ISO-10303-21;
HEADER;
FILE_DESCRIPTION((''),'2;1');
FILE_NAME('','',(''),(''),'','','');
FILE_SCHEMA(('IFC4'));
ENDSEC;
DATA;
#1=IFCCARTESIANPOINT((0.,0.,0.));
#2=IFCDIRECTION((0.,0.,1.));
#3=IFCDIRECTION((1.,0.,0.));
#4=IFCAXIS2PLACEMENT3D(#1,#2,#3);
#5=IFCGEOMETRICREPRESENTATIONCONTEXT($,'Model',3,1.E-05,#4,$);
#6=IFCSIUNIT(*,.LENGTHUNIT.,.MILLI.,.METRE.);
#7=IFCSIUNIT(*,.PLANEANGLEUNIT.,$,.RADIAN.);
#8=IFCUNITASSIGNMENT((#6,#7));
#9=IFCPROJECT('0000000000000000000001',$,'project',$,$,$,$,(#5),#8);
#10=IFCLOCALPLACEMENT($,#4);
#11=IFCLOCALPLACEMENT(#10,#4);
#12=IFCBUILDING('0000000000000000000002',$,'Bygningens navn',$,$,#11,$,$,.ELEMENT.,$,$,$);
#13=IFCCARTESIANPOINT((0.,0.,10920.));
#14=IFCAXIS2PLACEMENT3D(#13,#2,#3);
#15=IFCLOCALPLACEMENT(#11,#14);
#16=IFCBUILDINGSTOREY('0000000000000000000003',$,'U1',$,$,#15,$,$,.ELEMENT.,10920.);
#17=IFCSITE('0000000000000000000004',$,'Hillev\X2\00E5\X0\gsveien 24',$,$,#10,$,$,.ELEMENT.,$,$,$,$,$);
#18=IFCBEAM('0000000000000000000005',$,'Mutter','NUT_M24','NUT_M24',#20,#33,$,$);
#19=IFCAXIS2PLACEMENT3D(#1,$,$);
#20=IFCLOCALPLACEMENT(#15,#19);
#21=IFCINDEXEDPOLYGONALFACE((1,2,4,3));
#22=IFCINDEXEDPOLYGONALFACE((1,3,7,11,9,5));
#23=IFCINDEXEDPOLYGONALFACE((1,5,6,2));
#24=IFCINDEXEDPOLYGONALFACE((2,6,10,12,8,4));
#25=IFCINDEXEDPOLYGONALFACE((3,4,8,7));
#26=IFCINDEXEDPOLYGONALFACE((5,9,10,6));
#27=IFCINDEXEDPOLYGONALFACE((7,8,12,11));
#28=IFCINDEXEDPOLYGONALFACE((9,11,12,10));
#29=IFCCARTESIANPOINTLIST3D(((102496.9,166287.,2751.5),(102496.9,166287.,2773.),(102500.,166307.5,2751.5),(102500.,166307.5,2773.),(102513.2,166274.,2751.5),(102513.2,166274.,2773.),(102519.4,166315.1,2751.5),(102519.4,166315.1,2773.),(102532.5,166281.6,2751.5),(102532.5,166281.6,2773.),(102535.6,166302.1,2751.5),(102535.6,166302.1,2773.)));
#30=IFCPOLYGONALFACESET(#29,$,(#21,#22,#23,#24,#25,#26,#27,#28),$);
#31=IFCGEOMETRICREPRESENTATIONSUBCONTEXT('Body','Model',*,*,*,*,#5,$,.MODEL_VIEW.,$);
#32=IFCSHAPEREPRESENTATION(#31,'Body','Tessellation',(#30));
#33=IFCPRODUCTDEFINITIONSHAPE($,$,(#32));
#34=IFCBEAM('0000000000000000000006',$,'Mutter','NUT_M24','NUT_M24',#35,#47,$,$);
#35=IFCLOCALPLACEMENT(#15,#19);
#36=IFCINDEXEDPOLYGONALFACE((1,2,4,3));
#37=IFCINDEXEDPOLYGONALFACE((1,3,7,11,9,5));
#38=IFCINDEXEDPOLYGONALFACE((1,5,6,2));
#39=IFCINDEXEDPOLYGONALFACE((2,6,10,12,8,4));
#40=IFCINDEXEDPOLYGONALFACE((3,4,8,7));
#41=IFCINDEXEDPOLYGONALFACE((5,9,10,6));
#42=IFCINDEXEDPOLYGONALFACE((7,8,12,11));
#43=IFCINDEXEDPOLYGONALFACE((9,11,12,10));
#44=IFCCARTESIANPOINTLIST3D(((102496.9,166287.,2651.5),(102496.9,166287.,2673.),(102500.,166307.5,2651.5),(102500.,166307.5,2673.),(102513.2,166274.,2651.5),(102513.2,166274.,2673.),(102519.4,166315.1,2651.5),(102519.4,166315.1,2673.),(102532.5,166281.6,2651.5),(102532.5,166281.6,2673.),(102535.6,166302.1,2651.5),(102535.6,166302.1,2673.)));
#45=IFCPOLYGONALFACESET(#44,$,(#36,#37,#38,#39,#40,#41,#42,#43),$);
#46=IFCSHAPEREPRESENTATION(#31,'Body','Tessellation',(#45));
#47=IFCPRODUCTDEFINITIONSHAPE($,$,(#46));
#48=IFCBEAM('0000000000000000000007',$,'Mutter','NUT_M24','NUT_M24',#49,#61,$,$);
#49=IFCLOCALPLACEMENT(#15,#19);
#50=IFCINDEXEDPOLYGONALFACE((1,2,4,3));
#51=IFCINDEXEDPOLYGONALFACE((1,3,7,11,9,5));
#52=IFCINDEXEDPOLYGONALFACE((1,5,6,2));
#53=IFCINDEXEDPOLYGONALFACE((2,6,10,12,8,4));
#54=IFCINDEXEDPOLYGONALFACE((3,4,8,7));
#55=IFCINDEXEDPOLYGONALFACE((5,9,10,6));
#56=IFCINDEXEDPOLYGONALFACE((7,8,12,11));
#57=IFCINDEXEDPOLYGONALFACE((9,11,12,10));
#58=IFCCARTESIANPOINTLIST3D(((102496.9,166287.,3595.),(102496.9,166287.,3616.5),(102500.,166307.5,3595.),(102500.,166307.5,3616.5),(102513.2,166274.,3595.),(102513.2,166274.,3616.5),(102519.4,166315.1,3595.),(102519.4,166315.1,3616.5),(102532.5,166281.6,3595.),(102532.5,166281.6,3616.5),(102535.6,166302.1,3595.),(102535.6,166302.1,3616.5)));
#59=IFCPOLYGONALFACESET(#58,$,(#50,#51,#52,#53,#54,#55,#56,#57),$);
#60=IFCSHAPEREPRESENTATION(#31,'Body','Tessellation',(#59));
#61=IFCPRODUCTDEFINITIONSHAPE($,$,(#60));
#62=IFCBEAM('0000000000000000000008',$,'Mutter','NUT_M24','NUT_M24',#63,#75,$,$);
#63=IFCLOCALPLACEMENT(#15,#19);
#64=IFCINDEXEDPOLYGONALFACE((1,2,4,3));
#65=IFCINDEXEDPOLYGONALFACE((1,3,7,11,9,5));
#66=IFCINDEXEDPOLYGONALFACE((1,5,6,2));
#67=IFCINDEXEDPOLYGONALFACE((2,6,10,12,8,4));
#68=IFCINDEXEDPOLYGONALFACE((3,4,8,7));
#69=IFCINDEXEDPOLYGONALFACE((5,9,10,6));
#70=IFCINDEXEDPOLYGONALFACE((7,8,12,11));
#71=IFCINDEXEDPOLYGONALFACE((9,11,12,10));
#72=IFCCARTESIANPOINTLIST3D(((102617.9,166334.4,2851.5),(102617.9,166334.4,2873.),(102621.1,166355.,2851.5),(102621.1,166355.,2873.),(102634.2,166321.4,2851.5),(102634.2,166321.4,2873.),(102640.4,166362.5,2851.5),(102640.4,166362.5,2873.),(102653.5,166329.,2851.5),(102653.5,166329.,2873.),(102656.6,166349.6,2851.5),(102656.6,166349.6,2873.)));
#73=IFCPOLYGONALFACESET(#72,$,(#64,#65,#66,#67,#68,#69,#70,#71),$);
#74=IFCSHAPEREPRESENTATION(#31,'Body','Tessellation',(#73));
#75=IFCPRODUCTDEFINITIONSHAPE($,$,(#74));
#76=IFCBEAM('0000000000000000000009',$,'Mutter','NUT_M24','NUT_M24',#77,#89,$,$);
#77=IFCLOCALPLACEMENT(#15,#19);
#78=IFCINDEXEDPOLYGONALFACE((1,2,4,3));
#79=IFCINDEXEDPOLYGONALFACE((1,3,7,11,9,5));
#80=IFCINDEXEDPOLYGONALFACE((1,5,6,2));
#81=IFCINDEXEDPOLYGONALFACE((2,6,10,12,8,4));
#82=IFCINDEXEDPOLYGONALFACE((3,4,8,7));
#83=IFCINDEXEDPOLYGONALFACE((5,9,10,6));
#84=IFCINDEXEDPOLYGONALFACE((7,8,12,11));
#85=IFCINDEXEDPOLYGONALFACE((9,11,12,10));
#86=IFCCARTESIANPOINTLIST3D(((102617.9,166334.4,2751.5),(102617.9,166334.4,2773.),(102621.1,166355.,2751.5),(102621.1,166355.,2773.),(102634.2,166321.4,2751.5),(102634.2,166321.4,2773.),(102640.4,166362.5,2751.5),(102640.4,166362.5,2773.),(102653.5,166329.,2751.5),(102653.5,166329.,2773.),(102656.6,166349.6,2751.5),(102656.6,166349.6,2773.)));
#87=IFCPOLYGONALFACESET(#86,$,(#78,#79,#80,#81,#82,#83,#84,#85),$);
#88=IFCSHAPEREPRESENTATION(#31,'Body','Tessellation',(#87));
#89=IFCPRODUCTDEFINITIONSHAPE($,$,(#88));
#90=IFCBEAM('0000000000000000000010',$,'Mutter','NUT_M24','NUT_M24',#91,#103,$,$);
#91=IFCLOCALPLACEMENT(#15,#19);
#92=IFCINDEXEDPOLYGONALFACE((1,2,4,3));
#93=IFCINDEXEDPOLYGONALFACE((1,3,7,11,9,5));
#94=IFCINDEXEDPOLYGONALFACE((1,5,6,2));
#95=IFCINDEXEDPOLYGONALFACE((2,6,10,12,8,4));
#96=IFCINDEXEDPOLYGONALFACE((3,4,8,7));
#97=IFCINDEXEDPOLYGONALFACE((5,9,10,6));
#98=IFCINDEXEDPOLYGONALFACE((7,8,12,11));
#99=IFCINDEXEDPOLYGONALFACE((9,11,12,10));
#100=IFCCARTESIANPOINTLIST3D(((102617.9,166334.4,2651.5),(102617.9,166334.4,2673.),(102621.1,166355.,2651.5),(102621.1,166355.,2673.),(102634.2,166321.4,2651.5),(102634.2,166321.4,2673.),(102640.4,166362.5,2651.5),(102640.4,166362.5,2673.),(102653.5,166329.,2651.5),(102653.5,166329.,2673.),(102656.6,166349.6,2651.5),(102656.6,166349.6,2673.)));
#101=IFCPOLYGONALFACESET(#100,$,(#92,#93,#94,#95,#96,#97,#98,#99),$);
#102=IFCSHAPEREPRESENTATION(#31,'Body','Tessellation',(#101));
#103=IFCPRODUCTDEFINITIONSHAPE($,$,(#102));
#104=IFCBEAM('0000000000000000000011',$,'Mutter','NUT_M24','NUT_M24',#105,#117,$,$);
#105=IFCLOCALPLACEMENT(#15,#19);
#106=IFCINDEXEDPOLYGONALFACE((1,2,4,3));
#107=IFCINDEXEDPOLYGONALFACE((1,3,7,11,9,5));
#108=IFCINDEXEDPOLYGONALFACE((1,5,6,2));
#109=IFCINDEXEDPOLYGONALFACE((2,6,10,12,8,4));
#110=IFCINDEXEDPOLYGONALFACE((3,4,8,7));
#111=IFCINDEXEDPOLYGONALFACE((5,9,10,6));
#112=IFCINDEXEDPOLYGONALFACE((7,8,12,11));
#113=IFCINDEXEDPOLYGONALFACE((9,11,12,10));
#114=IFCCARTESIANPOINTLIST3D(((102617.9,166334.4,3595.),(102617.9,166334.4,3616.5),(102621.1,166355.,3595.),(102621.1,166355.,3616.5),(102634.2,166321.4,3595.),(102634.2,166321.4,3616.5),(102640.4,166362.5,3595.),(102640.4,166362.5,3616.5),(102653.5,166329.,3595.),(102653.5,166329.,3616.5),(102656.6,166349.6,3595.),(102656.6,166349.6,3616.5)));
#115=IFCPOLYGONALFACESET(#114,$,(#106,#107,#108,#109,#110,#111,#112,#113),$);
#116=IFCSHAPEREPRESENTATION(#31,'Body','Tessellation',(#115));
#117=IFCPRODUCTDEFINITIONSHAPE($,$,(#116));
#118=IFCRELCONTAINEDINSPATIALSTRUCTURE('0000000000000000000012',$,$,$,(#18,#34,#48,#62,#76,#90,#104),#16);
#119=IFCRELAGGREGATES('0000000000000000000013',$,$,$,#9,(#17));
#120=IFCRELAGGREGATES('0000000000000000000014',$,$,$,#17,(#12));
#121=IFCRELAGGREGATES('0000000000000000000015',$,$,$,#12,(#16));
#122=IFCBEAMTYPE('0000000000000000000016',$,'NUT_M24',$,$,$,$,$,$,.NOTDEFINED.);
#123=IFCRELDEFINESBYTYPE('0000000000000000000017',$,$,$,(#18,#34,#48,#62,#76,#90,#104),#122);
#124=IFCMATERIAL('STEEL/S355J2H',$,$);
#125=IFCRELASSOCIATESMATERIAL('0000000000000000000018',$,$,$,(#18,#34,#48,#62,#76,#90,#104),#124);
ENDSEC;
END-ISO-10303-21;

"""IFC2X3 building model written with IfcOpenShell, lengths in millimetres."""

from ifc_helpers import new_model, si_unit, frame, origin_with_axes, place, context, subcontext, project, spatial, polyline, outline, extrude, material, type_object, element, save


model = new_model("IFC2X3")

# Units and contexts
model_context = context("Model", 3, precision=1e-05, world=origin_with_axes())
body_context = subcontext(model_context, "Body", "Model", "MODEL_VIEW")
ifc_project = project(units=[si_unit("LENGTHUNIT", "METRE", prefix="MILLI"), si_unit("PLANEANGLEUNIT", "RADIAN")], contexts=[model_context])

# Site, building, storey
site_placement = place(None, origin_with_axes())
site = spatial("IfcSite", under=ifc_project, at=site_placement, Name="Hillevågsveien 24", CompositionType="ELEMENT")
building_placement = place(site_placement, origin_with_axes())
building = spatial("IfcBuilding", under=site, at=building_placement, Name="Bygningens navn", CompositionType="ELEMENT")
storey_placement = place(building_placement, frame((0.0, 0.0, 10920.0), z_axis=(0.0, 0.0, 1.0), x_axis=(1.0, 0.0, 0.0)))
storey = spatial("IfcBuildingStorey", under=building, at=storey_placement, Name="U1", CompositionType="ELEMENT", Elevation=10920.0)

# Beams
ifc_material_1 = material(Name="STEEL/S355J2H")
beam_type_1 = type_object("IfcBeamType", Name="NUT_M24", PredefinedType="NOTDEFINED")
for number, where, z_axis, x_axis, name in (
    (1, (102516.3, 166294.6, 2773.0), (-0.364877, 0.931056, 0.0), (0.0, 0.0, -1.0), "Mutter"),
    (2, (102516.3, 166294.6, 2673.0), (-0.364877, 0.931056, 0.0), (0.0, 0.0, -1.0), "Mutter"),
    (3, (102516.3, 166294.6, 3616.5), (-0.364877, 0.931056, 0.0), (0.0, 0.0, -1.0), "Mutter"),
    (4, (102637.3, 166342.0, 2873.0), (-0.364877, 0.931056, 0.0), (0.0, 0.0, -1.0), "Mutter"),
    (5, (102637.3, 166342.0, 2773.0), (-0.364877, 0.931056, 0.0), (0.0, 0.0, -1.0), "Mutter"),
    (6, (102637.3, 166342.0, 2673.0), (-0.364877, 0.931056, 0.0), (0.0, 0.0, -1.0), "Mutter"),
    (7, (102637.3, 166342.0, 3616.5), (-0.364877, 0.931056, 0.0), (0.0, 0.0, -1.0), "Mutter"),
):
    element("IfcBeam", number, at=place(storey_placement, frame(where, z_axis=z_axis, x_axis=x_axis)), inside=storey, type_object=beam_type_1, material=ifc_material_1, Name=name, Description="NUT_M24", ObjectType="NUT_M24", context=body_context, shape_type="SweptSolid", body=[
        extrude(outline(polyline([(-10.4, 18.0), (10.4, 18.0), (20.8, 0.0), (10.4, -18.0), (-10.4, -18.0), (-20.8, 0.0), (-10.4, 18.0)])), frame((21.5, 0.0, 0.0), z_axis=(-1.0, 0.0, 0.0), x_axis=(0.0, -1.0, 0.0)), (0.0, 0.0, 1.0), 21.5),
    ])

save(model, "model.ifc")
